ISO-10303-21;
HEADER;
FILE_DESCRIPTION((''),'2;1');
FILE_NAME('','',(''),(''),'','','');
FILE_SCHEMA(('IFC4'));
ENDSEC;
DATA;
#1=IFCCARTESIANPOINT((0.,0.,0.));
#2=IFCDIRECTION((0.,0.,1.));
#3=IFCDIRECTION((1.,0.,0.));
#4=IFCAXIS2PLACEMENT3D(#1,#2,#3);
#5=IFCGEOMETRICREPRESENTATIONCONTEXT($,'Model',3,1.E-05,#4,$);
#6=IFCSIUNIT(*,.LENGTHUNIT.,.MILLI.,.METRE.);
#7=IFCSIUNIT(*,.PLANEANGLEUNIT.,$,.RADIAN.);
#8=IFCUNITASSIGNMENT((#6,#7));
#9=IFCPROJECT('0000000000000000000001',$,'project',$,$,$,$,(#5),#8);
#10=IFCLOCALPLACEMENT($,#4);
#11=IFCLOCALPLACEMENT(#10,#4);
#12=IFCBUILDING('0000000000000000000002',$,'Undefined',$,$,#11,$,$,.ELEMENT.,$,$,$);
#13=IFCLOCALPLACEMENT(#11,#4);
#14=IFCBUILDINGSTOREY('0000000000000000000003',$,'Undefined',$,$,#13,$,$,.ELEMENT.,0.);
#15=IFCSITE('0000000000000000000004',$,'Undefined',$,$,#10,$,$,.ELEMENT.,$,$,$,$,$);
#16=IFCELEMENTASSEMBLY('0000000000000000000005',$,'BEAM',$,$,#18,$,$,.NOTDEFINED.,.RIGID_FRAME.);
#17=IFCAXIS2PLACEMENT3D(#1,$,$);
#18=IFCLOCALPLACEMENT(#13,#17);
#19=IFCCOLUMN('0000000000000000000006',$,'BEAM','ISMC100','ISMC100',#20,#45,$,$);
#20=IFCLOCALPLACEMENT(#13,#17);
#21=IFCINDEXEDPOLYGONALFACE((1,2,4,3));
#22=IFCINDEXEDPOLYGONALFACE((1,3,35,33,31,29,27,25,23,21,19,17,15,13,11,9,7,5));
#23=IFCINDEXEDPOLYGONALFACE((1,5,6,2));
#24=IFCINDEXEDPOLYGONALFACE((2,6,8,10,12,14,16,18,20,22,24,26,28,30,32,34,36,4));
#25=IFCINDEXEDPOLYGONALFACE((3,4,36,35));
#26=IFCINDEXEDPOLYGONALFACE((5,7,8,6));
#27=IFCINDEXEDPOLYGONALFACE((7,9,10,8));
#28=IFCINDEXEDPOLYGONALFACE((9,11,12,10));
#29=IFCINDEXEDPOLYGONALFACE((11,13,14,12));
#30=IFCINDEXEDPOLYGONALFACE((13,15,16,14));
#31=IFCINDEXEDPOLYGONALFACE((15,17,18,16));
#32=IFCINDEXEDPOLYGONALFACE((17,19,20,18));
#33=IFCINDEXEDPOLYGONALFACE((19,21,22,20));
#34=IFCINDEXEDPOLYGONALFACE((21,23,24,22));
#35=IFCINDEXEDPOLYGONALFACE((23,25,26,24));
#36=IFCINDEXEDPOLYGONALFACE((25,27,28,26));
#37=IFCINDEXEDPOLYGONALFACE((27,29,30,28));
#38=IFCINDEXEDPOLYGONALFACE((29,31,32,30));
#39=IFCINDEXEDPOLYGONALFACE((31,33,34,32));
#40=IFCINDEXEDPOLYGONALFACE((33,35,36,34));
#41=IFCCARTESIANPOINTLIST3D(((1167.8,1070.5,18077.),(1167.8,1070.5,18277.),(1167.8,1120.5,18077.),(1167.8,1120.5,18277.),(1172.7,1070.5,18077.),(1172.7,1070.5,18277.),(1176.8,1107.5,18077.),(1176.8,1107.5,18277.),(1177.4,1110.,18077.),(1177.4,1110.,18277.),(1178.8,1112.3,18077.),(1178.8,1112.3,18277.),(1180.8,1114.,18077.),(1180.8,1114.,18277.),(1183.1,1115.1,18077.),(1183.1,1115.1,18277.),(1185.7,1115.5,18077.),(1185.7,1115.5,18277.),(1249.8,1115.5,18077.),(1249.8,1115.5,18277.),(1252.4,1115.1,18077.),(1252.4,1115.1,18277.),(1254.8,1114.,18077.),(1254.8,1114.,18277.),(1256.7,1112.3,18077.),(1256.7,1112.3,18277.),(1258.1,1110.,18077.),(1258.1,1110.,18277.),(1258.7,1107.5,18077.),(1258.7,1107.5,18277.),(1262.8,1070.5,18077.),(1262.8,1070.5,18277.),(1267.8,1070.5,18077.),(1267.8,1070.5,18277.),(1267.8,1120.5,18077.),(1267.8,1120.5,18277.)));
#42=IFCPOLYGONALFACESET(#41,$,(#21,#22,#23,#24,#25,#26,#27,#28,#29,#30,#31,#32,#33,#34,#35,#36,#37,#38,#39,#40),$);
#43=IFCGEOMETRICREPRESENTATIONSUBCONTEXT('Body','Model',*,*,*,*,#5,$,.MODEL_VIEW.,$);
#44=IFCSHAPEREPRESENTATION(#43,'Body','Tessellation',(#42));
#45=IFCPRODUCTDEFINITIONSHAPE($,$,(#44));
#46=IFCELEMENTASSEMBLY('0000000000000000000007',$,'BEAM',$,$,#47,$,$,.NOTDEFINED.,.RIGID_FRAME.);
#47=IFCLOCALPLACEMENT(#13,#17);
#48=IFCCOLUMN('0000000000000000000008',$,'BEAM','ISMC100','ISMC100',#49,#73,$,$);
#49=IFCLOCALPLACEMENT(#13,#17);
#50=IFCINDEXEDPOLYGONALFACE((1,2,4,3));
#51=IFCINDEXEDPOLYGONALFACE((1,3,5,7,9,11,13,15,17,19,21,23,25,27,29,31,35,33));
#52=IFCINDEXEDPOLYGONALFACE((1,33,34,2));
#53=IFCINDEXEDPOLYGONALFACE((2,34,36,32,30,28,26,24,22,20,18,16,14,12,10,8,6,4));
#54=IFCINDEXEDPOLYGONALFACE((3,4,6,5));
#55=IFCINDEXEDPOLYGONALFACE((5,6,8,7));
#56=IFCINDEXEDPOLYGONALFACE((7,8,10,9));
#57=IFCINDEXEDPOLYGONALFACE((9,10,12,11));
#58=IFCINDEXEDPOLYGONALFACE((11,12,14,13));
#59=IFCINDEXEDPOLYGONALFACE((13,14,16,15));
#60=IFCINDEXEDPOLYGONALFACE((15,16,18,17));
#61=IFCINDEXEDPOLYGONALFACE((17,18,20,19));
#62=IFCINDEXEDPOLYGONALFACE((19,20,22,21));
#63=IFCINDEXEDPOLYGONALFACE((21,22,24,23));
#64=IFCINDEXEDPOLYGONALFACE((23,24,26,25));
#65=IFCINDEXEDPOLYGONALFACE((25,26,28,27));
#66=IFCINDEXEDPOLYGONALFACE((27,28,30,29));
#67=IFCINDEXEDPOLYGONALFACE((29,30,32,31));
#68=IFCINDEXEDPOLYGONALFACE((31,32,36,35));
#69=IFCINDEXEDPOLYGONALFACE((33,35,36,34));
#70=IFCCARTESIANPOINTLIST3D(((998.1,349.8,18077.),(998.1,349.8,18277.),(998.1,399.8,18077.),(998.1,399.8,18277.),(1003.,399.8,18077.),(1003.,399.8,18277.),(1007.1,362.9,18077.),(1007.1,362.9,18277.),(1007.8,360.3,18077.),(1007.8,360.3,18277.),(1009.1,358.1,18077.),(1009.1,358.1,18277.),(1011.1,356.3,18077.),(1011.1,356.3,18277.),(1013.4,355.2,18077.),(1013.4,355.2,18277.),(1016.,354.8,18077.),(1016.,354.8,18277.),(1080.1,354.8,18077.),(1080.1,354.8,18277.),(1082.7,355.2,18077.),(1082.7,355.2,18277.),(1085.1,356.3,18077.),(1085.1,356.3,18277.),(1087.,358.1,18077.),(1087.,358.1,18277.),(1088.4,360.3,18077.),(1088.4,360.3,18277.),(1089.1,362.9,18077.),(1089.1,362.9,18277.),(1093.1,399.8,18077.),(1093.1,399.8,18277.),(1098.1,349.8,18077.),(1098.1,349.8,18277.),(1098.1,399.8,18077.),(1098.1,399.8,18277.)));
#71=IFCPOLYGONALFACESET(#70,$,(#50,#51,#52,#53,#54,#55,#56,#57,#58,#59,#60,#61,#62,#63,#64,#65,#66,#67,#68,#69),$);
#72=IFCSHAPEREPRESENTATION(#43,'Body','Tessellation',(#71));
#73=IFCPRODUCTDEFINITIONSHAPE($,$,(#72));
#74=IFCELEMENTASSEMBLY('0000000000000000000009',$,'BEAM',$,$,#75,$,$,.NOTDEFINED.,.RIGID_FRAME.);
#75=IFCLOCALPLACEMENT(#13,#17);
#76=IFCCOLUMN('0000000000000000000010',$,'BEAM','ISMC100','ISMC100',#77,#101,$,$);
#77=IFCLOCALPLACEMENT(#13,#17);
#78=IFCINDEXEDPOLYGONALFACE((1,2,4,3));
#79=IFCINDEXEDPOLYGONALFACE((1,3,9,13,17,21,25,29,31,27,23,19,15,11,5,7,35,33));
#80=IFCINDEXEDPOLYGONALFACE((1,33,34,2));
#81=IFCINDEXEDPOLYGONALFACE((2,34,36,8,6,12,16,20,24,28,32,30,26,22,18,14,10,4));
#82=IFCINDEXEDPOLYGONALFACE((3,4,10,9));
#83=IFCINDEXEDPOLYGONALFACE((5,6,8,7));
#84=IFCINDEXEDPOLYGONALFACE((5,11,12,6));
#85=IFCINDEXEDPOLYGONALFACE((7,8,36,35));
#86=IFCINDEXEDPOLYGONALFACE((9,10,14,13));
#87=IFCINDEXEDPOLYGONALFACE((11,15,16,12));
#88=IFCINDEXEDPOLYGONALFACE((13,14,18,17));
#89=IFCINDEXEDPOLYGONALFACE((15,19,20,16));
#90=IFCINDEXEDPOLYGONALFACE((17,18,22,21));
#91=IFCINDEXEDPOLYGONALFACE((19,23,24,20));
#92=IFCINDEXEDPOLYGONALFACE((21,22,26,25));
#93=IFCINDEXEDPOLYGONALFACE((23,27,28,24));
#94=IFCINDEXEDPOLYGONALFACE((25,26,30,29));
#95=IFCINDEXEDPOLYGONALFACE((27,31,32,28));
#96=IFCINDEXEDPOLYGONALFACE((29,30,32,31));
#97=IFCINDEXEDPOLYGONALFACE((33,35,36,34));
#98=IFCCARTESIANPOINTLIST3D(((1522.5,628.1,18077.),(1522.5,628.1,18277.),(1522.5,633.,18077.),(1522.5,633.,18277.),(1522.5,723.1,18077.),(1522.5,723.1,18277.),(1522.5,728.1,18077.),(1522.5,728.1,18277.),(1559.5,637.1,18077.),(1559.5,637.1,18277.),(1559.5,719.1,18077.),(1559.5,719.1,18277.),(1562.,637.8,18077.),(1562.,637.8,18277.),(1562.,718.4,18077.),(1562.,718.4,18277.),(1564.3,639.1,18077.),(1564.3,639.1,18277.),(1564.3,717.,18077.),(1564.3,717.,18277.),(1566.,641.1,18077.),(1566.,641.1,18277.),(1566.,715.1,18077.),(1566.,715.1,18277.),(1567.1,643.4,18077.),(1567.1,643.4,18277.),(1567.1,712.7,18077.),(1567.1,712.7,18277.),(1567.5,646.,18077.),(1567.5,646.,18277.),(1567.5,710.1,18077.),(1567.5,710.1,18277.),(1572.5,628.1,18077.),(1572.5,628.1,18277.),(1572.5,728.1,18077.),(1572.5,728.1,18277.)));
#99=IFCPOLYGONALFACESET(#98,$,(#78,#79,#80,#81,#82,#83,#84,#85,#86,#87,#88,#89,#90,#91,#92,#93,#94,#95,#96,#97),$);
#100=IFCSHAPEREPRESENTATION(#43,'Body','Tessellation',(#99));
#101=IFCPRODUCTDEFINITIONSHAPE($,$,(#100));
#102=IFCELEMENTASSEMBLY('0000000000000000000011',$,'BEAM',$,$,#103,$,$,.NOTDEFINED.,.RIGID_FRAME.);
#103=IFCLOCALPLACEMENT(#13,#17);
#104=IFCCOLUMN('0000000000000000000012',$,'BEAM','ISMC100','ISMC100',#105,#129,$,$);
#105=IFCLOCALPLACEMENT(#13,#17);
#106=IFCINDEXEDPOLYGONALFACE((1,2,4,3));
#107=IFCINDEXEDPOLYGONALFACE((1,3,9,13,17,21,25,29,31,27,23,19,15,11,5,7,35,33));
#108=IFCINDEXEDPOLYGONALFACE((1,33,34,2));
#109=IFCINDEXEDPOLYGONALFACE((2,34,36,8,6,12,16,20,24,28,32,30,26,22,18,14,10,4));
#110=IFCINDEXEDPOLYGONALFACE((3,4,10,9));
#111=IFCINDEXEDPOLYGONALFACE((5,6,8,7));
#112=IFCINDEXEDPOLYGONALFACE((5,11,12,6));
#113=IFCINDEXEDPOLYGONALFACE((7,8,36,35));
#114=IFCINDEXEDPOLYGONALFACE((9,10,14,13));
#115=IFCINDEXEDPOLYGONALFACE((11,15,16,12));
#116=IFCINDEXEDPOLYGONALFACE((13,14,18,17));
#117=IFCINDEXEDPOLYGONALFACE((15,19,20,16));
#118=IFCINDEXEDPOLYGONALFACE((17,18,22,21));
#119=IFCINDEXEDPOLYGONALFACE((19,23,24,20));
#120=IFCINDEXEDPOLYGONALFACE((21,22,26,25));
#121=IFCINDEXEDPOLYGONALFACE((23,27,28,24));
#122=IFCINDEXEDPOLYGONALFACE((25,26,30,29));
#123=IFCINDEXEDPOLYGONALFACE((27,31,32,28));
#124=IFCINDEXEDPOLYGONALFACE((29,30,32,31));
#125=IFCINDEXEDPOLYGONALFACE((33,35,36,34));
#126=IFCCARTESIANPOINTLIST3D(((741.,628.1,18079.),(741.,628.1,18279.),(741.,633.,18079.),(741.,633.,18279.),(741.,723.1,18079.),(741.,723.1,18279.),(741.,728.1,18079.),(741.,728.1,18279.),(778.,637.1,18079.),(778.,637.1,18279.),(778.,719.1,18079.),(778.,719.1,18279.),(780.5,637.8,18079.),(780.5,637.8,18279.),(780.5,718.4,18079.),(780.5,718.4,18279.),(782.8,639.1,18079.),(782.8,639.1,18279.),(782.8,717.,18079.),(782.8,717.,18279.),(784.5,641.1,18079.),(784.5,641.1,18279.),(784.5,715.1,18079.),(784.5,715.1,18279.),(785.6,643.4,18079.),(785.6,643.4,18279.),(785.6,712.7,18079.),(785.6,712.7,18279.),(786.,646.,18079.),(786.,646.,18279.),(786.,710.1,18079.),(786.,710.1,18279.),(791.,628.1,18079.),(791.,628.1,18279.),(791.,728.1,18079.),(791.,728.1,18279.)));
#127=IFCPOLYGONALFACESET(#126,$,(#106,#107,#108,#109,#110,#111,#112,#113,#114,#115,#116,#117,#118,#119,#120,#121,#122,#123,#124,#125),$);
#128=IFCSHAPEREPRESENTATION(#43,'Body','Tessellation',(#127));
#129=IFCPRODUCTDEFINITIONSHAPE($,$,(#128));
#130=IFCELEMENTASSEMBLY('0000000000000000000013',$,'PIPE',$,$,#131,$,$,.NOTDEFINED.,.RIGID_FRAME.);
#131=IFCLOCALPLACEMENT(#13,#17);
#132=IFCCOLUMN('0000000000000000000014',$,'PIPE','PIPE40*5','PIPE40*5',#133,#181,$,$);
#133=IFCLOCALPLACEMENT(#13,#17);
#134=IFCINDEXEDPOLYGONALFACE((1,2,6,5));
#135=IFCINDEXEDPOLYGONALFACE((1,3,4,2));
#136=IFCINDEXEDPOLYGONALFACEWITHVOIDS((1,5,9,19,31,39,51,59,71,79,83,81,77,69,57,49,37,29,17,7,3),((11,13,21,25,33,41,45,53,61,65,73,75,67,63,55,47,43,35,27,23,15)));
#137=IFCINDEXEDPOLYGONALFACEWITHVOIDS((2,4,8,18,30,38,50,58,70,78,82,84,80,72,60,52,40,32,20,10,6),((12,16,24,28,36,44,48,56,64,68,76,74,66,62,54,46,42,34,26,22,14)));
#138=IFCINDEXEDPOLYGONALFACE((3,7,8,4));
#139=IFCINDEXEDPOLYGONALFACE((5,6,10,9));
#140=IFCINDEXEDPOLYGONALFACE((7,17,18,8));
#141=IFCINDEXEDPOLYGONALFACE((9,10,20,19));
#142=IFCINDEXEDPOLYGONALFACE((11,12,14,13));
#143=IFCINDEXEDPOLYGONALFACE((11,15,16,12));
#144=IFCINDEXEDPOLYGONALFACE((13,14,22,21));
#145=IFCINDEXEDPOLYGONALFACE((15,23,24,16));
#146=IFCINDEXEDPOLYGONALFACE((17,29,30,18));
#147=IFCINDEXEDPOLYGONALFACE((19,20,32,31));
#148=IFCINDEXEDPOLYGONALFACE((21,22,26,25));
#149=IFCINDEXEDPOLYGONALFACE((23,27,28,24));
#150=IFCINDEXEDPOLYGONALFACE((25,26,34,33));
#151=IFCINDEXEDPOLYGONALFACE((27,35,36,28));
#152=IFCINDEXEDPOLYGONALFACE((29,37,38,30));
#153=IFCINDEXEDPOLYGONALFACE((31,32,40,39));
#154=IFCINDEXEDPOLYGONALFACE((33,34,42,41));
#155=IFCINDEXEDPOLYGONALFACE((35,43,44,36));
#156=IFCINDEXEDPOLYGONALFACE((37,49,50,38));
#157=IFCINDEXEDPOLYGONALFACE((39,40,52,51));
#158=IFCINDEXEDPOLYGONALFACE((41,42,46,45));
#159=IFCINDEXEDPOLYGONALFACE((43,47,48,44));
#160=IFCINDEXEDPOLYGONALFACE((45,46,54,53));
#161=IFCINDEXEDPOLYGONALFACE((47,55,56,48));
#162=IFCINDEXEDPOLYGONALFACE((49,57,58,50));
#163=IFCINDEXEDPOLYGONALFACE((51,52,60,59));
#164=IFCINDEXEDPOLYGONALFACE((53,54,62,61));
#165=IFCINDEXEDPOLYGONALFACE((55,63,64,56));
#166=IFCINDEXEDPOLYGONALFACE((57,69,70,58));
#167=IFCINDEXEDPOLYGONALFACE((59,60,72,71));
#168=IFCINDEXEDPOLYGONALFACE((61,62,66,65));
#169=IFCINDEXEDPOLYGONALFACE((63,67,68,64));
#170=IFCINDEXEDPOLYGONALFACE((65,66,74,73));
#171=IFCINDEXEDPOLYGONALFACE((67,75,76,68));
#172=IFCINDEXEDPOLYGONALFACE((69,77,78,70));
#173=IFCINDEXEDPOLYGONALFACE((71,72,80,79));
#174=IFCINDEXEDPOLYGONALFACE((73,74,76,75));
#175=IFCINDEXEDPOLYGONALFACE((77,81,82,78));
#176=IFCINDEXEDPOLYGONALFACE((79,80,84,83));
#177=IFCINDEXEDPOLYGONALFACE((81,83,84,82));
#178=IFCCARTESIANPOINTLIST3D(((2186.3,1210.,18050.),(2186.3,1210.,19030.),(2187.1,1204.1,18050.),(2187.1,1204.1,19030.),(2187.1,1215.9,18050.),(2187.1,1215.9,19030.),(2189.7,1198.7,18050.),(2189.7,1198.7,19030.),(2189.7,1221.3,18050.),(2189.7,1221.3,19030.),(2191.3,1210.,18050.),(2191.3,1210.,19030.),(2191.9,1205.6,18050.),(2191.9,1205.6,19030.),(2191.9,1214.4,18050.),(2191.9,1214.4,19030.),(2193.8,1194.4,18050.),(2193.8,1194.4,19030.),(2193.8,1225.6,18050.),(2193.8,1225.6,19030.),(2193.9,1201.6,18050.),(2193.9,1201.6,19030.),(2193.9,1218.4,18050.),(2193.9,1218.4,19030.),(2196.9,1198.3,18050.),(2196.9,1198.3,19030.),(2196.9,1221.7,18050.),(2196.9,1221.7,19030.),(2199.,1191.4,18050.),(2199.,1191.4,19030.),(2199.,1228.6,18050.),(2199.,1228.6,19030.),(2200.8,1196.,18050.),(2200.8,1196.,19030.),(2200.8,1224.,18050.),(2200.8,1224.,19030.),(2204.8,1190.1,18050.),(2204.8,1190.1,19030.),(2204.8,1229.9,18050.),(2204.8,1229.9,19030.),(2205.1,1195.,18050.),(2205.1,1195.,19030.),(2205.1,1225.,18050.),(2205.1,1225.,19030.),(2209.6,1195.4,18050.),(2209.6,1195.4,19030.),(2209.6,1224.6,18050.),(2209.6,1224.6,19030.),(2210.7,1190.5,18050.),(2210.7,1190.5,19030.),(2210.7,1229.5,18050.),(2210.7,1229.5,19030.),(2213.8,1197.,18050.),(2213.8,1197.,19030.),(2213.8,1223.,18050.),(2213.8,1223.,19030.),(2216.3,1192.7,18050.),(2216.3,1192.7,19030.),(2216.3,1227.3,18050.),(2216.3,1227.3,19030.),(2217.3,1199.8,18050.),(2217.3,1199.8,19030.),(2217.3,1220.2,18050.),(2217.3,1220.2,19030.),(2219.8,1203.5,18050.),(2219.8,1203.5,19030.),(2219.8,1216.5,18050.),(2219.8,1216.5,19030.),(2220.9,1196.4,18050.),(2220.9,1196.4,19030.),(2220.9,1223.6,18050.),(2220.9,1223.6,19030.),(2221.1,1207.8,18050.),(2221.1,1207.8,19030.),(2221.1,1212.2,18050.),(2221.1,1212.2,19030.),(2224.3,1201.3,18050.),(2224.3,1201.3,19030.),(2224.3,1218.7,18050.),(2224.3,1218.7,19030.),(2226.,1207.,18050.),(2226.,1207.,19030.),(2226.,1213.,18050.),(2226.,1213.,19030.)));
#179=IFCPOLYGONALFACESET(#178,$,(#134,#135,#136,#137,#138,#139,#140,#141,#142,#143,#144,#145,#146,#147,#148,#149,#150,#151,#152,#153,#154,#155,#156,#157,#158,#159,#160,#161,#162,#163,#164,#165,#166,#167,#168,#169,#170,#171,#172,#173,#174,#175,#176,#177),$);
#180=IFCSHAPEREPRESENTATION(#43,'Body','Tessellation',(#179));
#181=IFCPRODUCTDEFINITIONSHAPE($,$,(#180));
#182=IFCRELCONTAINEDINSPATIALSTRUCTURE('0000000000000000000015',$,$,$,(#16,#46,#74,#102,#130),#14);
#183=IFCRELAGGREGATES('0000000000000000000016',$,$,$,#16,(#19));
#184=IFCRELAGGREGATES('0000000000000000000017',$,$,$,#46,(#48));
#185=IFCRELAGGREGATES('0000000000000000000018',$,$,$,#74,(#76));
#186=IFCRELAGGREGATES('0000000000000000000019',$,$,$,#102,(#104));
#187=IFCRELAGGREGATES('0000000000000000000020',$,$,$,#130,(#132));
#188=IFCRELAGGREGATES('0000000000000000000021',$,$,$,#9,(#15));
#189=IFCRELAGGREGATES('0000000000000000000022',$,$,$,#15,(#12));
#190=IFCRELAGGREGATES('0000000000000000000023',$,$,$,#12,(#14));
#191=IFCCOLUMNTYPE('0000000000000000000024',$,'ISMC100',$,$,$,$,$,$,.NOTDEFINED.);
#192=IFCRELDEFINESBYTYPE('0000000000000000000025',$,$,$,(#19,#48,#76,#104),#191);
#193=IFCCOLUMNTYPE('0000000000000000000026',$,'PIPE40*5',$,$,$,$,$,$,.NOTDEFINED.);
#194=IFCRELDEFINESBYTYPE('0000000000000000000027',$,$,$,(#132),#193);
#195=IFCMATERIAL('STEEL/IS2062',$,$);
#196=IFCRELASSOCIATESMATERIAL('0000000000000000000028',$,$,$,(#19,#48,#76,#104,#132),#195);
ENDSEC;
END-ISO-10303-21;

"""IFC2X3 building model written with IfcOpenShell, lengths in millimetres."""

from ifc_helpers import new_model, si_unit, frame, origin_with_axes, origin_2d_with_axis, place, context, subcontext, project, spatial, hollow_circle, u_section, extrude, clip, halfspace, material, type_object, element, aggregate, save


model = new_model("IFC2X3")

# Units and contexts
model_context = context("Model", 3, precision=1e-05, world=origin_with_axes())
body_context = subcontext(model_context, "Body", "Model", "MODEL_VIEW")
ifc_project = project(units=[si_unit("LENGTHUNIT", "METRE", prefix="MILLI"), si_unit("PLANEANGLEUNIT", "RADIAN")], contexts=[model_context])

# Site, building, storey
site_placement = place(None, origin_with_axes())
site = spatial("IfcSite", under=ifc_project, at=site_placement, Name="Undefined", CompositionType="ELEMENT")
building_placement = place(site_placement, origin_with_axes())
building = spatial("IfcBuilding", under=site, at=building_placement, Name="Undefined", CompositionType="ELEMENT")
storey_placement = place(building_placement, origin_with_axes())
storey = spatial("IfcBuildingStorey", under=building, at=storey_placement, Name="Undefined", CompositionType="ELEMENT", Elevation=0.0)

# Element assemblies, columns
assembly_1_placement = place(storey_placement, origin_with_axes())
assembly_1 = element("IfcElementAssembly", 1, at=assembly_1_placement, inside=storey, Name="BEAM", AssemblyPlace="NOTDEFINED", PredefinedType="RIGID_FRAME")
ifc_material_1 = material(Name="STEEL/IS2062")
column_type_1 = type_object("IfcColumnType", Name="ISMC100", PredefinedType="NOTDEFINED")
column_1_placement = place(assembly_1_placement, frame((1217.8, 1095.5, 18077.0), z_axis=(0.0, 0.0, 1.0), x_axis=(-1.0, 0.0, 0.0)))
column_1 = element("IfcColumn", 2, at=column_1_placement, type_object=column_type_1, material=ifc_material_1, Name="BEAM", Description="ISMC100", ObjectType="ISMC100", context=body_context, shape_type="SweptSolid", body=[
    extrude(u_section(Depth=100.0, FlangeWidth=50.0, WebThickness=5.0, FlangeThickness=7.7, FilletRadius=9.0, FlangeSlope=0.10956, at=origin_2d_with_axis()), frame((0.0, 0.0, 200.0), z_axis=(0.0, 0.0, -1.0), x_axis=(0.0, 1.0, 0.0)), (0.0, 0.0, 1.0), 200.0),
])
aggregate(assembly_1, [column_1])
assembly_2_placement = place(storey_placement, origin_with_axes())
assembly_2 = element("IfcElementAssembly", 3, at=assembly_2_placement, inside=storey, Name="BEAM", AssemblyPlace="NOTDEFINED", PredefinedType="RIGID_FRAME")
column_2_placement = place(assembly_2_placement, frame((1048.1, 374.8, 18077.0), z_axis=(0.0, 0.0, 1.0), x_axis=(1.0, 0.0, 0.0)))
column_2 = element("IfcColumn", 4, at=column_2_placement, type_object=column_type_1, material=ifc_material_1, Name="BEAM", Description="ISMC100", ObjectType="ISMC100", context=body_context, shape_type="SweptSolid", body=[
    extrude(u_section(Depth=100.0, FlangeWidth=50.0, WebThickness=5.0, FlangeThickness=7.7, FilletRadius=9.0, FlangeSlope=0.10956, at=origin_2d_with_axis()), frame((0.0, 0.0, 200.0), z_axis=(0.0, 0.0, -1.0), x_axis=(0.0, 1.0, 0.0)), (0.0, 0.0, 1.0), 200.0),
])
aggregate(assembly_2, [column_2])
assembly_3_placement = place(storey_placement, origin_with_axes())
assembly_3 = element("IfcElementAssembly", 5, at=assembly_3_placement, inside=storey, Name="BEAM", AssemblyPlace="NOTDEFINED", PredefinedType="RIGID_FRAME")
column_3_placement = place(assembly_3_placement, frame((1547.5, 678.1, 18077.0), z_axis=(0.0, 0.0, 1.0), x_axis=(0.0, 1.0, 0.0)))
column_3 = element("IfcColumn", 6, at=column_3_placement, type_object=column_type_1, material=ifc_material_1, Name="BEAM", Description="ISMC100", ObjectType="ISMC100", context=body_context, shape_type="SweptSolid", body=[
    extrude(u_section(Depth=100.0, FlangeWidth=50.0, WebThickness=5.0, FlangeThickness=7.7, FilletRadius=9.0, FlangeSlope=0.10956, at=origin_2d_with_axis()), frame((0.0, 0.0, 200.0), z_axis=(0.0, 0.0, -1.0), x_axis=(0.0, 1.0, 0.0)), (0.0, 0.0, 1.0), 200.0),
])
aggregate(assembly_3, [column_3])
assembly_4_placement = place(storey_placement, origin_with_axes())
assembly_4 = element("IfcElementAssembly", 7, at=assembly_4_placement, inside=storey, Name="BEAM", AssemblyPlace="NOTDEFINED", PredefinedType="RIGID_FRAME")
column_4_placement = place(assembly_4_placement, frame((766.0, 678.1, 18079.0), z_axis=(0.0, 0.0, 1.0), x_axis=(0.0, 1.0, 0.0)))
column_4 = element("IfcColumn", 8, at=column_4_placement, type_object=column_type_1, material=ifc_material_1, Name="BEAM", Description="ISMC100", ObjectType="ISMC100", context=body_context, shape_type="SweptSolid", body=[
    extrude(u_section(Depth=100.0, FlangeWidth=50.0, WebThickness=5.0, FlangeThickness=7.7, FilletRadius=9.0, FlangeSlope=0.10956, at=origin_2d_with_axis()), frame((0.0, 0.0, 200.0), z_axis=(0.0, 0.0, -1.0), x_axis=(0.0, 1.0, 0.0)), (0.0, 0.0, 1.0), 200.0),
])
aggregate(assembly_4, [column_4])
assembly_5_placement = place(storey_placement, origin_with_axes())
assembly_5 = element("IfcElementAssembly", 9, at=assembly_5_placement, inside=storey, Name="PIPE", AssemblyPlace="NOTDEFINED", PredefinedType="RIGID_FRAME")
column_type_2 = type_object("IfcColumnType", Name="PIPE40*5", PredefinedType="NOTDEFINED")
column_5_placement = place(assembly_5_placement, frame((2206.3, 1210.0, 18050.0), z_axis=(0.0, 0.0, 1.0), x_axis=(0.0, 1.0, 0.0)))
column_5 = element("IfcColumn", 10, at=column_5_placement, type_object=column_type_2, material=ifc_material_1, Name="PIPE", Description="PIPE40*5", ObjectType="PIPE40*5", context=body_context, shape_type="Clipping", body=[
    clip(extrude(hollow_circle(Radius=20.0, WallThickness=5.0, at=origin_2d_with_axis()), frame((0.0, 0.0, 1000.0), z_axis=(0.0, 0.0, -1.0), x_axis=(0.0, 1.0, 0.0)), (0.0, 0.0, 1.0), 1000.0), halfspace(frame((0.0, 0.0, 980.0), z_axis=(0.0, 0.0, 1.0), x_axis=(1.0, 0.0, 0.0)), False)),
])
aggregate(assembly_5, [column_5])

save(model, "model.ifc")
